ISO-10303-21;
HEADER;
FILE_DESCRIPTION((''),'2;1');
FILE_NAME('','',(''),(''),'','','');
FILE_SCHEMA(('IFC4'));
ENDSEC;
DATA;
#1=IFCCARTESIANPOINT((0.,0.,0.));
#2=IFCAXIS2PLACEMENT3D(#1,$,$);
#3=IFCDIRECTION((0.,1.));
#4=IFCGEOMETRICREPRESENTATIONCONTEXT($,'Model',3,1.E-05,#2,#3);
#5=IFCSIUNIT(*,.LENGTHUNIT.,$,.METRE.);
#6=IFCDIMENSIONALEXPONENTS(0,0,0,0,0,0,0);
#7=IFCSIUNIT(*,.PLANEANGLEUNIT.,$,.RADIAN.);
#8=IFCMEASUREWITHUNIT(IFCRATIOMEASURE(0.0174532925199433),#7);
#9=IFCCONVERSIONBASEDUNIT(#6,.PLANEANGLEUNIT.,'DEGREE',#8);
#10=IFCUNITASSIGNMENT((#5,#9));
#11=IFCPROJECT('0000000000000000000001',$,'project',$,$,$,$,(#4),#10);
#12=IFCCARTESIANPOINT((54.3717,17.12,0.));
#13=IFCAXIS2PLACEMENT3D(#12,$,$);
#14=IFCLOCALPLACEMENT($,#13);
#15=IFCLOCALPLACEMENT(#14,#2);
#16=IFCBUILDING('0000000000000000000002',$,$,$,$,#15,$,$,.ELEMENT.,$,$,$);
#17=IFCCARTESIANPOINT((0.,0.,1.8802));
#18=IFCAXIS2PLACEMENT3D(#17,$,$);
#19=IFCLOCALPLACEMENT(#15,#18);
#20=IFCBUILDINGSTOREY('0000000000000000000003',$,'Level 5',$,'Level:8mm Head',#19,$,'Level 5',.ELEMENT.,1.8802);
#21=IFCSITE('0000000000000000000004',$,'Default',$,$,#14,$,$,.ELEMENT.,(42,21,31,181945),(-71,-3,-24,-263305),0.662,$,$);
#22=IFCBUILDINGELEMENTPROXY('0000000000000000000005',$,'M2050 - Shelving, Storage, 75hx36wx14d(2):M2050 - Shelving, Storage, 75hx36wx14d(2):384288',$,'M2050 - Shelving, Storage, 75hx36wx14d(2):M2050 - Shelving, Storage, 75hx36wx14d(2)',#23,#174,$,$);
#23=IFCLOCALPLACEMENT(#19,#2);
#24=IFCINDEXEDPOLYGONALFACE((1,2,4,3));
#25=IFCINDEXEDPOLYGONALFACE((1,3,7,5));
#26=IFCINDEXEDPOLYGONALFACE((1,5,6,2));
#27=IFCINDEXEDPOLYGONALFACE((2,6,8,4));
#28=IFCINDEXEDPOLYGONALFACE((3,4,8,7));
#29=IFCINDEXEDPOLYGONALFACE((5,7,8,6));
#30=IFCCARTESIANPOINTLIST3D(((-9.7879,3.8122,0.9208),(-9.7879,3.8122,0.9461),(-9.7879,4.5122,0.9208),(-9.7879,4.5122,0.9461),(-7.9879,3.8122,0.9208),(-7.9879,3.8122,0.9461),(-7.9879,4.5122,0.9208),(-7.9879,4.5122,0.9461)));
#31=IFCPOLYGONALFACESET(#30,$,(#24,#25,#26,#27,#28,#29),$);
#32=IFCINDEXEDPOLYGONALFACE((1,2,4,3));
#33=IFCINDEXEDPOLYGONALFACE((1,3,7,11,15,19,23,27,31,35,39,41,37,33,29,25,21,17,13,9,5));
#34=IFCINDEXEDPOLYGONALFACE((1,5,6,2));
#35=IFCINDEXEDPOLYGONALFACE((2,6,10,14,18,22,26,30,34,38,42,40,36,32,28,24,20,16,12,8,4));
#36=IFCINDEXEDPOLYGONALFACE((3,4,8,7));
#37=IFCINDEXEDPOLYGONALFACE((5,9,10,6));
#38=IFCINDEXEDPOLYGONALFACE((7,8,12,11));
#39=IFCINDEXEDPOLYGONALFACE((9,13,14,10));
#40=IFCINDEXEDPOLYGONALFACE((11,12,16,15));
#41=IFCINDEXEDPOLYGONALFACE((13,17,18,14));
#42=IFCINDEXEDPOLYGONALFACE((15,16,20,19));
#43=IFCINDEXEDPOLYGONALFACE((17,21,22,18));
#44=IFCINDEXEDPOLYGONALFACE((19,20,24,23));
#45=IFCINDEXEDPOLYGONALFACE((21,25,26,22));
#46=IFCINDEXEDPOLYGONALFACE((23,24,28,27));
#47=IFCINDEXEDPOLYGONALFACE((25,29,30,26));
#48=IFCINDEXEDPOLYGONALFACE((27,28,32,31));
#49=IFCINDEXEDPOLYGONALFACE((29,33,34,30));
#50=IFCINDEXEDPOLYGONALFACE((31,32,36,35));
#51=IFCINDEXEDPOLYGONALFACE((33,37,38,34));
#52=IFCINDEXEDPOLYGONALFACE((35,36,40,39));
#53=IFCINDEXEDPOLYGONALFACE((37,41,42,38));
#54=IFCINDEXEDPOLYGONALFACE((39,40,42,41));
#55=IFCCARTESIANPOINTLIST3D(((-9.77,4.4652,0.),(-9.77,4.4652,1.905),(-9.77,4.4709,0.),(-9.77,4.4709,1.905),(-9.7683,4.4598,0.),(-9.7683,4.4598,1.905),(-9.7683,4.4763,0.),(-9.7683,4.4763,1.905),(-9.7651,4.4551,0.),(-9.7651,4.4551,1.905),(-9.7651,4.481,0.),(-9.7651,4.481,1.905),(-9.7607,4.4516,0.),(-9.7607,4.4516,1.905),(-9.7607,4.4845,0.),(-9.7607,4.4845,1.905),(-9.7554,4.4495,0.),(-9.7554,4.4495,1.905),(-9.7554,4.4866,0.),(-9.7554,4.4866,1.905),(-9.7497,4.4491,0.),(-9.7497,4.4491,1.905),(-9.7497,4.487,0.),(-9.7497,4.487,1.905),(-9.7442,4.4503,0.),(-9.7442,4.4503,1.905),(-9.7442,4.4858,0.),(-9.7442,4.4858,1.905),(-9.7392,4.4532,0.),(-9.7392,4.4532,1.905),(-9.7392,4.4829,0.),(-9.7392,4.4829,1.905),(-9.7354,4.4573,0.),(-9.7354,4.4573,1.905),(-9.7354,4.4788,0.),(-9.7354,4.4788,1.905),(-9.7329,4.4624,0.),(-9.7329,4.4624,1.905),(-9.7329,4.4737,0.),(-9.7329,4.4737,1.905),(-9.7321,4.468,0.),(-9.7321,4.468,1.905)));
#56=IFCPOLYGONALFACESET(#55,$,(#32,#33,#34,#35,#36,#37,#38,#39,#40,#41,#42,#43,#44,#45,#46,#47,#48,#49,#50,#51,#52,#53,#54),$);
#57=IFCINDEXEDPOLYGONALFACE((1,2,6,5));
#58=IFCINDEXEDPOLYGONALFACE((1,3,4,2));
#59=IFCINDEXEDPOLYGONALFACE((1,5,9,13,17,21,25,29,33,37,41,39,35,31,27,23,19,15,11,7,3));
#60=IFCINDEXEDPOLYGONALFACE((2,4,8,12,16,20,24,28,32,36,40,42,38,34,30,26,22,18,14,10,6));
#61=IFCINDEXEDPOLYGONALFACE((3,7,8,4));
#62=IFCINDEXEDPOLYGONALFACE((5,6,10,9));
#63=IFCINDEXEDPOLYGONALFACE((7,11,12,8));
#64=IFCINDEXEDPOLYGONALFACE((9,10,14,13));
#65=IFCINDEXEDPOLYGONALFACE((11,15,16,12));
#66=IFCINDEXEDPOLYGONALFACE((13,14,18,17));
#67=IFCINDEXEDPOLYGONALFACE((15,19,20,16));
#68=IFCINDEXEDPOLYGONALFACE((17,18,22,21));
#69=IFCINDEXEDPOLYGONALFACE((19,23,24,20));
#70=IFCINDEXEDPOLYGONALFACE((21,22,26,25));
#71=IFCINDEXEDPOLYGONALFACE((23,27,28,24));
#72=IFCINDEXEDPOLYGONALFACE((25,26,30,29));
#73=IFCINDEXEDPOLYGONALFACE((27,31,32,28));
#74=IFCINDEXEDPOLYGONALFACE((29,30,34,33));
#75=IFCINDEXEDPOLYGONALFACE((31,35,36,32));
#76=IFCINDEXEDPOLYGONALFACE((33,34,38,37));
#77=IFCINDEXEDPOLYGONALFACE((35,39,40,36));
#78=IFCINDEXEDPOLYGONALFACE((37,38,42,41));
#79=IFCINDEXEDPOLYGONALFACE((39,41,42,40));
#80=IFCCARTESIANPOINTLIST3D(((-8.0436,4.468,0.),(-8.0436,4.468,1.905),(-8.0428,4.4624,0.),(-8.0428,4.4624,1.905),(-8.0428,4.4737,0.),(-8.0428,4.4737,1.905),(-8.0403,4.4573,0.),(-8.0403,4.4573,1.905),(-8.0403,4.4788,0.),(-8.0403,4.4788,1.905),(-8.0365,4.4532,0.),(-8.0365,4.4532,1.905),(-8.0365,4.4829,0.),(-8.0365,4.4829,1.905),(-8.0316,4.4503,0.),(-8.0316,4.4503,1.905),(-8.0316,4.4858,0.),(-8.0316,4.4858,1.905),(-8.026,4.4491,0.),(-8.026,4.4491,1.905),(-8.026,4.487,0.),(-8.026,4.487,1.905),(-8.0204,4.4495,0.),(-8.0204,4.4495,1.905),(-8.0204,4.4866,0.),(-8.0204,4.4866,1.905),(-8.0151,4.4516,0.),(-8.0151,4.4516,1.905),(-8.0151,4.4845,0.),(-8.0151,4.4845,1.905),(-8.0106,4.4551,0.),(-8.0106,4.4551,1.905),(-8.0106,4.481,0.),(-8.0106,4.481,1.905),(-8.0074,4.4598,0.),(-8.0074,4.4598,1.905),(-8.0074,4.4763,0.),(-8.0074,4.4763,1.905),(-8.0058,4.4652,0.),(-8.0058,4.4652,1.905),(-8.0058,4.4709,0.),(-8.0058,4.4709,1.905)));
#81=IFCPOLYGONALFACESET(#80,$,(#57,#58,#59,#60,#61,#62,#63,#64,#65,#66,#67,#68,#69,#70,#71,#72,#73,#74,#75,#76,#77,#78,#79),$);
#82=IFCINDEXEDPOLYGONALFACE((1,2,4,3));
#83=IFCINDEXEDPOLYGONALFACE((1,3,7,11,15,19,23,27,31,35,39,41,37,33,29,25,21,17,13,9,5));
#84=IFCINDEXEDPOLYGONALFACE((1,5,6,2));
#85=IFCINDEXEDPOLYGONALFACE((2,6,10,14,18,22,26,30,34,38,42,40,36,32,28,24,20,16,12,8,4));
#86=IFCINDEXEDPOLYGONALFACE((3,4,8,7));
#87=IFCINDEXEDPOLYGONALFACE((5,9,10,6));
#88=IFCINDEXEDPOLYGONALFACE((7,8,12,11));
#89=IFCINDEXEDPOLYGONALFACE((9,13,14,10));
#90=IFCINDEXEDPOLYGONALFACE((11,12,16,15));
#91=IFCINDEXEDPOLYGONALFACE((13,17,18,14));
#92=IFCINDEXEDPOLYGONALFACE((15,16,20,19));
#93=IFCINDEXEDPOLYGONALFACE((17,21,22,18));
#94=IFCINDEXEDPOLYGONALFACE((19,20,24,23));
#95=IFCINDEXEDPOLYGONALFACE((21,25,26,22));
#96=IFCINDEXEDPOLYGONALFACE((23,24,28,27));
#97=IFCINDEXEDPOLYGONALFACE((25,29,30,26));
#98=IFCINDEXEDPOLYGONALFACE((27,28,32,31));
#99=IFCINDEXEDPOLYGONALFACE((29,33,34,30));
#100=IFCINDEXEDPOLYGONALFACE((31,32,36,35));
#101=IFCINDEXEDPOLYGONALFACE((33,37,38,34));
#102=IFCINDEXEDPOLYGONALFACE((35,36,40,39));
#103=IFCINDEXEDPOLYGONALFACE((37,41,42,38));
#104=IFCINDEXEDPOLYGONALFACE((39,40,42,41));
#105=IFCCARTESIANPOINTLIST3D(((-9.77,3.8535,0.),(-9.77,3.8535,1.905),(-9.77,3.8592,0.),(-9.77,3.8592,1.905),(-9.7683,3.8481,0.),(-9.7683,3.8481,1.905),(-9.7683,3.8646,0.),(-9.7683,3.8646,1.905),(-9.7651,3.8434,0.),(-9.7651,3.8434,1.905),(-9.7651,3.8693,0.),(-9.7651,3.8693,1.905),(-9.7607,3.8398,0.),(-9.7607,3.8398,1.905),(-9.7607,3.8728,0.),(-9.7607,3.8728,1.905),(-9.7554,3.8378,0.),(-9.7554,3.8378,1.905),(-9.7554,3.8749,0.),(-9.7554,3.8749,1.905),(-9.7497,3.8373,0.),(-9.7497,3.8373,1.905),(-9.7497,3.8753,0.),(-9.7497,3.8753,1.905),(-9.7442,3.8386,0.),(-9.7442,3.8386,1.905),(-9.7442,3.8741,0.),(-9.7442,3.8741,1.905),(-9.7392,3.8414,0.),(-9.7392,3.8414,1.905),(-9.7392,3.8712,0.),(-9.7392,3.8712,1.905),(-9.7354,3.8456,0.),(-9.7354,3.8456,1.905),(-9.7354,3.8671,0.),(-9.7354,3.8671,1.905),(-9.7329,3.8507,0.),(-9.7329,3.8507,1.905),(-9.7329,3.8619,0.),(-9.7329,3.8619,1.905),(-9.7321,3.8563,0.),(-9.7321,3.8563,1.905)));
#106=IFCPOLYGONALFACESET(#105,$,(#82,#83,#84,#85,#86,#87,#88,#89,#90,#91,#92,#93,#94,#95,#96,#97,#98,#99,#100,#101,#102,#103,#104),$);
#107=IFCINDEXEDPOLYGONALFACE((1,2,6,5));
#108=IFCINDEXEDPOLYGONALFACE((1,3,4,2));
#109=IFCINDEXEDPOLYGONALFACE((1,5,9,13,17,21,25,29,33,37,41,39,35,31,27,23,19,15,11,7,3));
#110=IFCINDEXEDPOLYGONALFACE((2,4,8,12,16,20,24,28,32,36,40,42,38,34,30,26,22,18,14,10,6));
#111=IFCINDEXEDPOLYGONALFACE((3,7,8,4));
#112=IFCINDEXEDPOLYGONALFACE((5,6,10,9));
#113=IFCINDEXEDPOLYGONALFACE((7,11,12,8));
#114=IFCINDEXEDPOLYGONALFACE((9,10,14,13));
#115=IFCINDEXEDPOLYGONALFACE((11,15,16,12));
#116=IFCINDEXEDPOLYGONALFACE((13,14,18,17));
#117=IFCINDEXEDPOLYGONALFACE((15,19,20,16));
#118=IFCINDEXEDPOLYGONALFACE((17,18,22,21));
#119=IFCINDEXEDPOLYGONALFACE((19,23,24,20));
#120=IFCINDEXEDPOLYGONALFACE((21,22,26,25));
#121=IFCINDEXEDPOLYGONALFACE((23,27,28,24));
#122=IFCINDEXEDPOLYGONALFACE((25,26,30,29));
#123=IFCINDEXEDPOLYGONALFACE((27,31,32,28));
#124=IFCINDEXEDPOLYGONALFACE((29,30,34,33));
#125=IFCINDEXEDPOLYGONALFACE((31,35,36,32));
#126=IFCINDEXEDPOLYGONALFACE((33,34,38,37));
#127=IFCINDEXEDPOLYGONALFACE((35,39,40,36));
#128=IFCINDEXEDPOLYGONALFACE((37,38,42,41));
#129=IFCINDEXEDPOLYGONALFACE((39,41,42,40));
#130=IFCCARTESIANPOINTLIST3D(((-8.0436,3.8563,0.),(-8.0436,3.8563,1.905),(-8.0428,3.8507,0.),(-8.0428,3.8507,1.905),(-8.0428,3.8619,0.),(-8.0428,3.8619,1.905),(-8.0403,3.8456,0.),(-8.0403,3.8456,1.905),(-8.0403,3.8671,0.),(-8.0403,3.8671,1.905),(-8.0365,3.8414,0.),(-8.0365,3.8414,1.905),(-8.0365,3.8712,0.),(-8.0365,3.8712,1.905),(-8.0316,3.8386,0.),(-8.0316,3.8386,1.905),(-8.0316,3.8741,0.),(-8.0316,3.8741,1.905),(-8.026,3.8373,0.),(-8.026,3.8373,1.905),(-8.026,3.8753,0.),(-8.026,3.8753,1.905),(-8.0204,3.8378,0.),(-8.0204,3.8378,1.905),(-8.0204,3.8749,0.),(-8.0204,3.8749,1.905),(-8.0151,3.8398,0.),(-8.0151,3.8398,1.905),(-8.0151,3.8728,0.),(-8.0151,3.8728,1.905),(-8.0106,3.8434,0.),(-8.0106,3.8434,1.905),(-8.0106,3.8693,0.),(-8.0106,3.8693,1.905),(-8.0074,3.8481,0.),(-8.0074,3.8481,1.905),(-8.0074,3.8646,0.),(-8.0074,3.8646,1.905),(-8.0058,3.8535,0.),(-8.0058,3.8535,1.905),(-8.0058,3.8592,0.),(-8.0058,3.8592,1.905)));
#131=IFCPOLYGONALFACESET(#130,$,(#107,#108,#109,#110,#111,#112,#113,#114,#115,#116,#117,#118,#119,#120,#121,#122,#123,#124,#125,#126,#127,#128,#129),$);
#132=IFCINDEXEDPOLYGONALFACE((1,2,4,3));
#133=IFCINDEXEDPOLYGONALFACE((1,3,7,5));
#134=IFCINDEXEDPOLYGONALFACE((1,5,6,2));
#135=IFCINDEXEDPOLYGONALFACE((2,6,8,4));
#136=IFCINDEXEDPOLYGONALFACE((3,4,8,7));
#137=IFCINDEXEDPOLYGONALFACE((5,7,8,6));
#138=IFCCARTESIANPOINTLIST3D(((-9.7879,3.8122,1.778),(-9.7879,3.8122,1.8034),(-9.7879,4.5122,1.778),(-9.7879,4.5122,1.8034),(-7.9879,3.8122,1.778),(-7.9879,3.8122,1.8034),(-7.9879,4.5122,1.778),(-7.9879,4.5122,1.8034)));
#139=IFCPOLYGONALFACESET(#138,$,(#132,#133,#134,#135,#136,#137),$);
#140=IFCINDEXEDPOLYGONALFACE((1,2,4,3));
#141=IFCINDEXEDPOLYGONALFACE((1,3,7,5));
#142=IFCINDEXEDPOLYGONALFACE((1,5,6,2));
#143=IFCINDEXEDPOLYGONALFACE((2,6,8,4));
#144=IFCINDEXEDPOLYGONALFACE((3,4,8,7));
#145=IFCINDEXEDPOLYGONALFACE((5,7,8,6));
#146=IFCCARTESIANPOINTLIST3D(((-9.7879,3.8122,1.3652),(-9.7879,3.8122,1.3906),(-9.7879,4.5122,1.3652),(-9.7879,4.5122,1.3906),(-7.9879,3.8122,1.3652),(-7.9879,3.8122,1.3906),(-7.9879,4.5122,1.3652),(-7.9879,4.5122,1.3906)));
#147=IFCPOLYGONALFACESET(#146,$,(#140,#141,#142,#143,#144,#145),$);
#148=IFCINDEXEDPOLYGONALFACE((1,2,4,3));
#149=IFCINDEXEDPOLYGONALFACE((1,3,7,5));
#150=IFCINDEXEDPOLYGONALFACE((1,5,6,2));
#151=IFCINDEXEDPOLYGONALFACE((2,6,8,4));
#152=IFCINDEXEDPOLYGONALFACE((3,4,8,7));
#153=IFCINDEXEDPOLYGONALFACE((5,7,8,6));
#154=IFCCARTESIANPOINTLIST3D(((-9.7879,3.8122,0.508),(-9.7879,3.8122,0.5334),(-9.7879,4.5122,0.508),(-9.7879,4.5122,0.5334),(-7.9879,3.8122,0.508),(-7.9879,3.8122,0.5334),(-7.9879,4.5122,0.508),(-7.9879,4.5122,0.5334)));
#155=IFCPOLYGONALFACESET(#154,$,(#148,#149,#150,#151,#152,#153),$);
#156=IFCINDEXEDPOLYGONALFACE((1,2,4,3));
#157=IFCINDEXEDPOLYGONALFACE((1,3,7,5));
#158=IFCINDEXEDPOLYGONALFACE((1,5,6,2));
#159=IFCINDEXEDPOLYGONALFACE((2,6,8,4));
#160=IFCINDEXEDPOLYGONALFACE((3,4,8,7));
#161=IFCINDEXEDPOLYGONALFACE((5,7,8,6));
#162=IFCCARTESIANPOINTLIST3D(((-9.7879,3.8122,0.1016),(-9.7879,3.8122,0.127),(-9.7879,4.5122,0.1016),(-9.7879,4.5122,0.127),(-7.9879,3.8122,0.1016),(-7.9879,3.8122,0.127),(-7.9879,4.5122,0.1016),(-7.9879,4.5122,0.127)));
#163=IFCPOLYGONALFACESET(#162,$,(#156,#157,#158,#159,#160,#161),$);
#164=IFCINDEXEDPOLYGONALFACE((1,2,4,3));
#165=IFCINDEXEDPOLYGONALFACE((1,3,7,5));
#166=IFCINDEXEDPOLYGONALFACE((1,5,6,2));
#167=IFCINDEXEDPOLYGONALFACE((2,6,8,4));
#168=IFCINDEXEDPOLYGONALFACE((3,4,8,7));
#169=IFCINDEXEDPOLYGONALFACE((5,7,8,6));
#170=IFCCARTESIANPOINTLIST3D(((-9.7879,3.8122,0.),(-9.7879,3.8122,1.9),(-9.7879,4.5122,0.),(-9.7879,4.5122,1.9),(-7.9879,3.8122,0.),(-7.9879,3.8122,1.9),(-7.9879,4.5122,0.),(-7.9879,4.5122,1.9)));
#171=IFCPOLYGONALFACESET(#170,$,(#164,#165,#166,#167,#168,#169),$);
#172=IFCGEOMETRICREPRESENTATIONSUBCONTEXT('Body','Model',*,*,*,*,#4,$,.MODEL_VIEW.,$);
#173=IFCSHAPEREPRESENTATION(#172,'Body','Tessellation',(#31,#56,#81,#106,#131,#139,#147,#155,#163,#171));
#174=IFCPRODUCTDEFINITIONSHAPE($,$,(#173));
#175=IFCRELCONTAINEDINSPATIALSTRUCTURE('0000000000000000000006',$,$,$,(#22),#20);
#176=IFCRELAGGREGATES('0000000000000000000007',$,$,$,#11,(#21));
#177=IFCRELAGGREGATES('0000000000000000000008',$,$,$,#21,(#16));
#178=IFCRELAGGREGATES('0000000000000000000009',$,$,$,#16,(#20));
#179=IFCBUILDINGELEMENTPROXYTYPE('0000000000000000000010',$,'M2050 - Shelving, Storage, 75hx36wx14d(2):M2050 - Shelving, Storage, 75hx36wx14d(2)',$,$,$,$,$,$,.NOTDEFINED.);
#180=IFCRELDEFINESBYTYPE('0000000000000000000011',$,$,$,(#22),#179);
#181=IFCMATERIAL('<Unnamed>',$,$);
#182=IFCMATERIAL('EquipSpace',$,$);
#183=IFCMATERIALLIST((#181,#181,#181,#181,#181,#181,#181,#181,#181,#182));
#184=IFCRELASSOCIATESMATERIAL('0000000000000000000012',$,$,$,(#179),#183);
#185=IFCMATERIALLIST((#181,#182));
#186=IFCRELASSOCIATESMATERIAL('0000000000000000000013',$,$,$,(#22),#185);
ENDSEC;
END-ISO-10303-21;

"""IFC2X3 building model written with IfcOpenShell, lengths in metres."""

from ifc_helpers import new_model, entity, si_unit, converted_unit, direction, frame, frame_2d, origin, origin_2d_with_axis, place, context, subcontext, project, spatial, rectangle, circle, extrude, source, transform, mapped, material, material_list, type_object, type_shapes, element, save


model = new_model("IFC2X3")

# Units and contexts
model_context = context("Model", 3, precision=1e-05, world=origin(), true_north=direction((0.0, 1.0)))
body_context = subcontext(model_context, "Body", "Model", "MODEL_VIEW")
ifc_project = project(units=[si_unit("LENGTHUNIT", "METRE"), converted_unit("PLANEANGLEUNIT", "DEGREE", entity("IfcRatioMeasure", 0.0174532925199433), si_unit("PLANEANGLEUNIT", "RADIAN"), dimensions=[0, 0, 0, 0, 0, 0, 0])], contexts=[model_context])

# Site, building, storey
site_placement = place(None, frame((54.3717, 17.12, 0.0)))
site = spatial("IfcSite", under=ifc_project, at=site_placement, Name="Default", CompositionType="ELEMENT", RefLatitude=(42, 21, 31, 181945), RefLongitude=(-71, -3, -24, -263305), RefElevation=0.662)
building_placement = place(site_placement, origin())
building = spatial("IfcBuilding", under=site, at=building_placement, CompositionType="ELEMENT")
storey_placement = place(building_placement, frame((0.0, 0.0, 1.8802)))
storey = spatial("IfcBuildingStorey", under=building, at=storey_placement, Name="Level 5", ObjectType="Level:8mm Head", LongName="Level 5", CompositionType="ELEMENT", Elevation=1.8802)

# Building element proxy
ifc_material_1 = material(Name="<Unnamed>")
ifc_material_2 = material(Name="EquipSpace")
ifc_material_list_1 = material_list([ifc_material_1, ifc_material_1, ifc_material_1, ifc_material_1, ifc_material_1, ifc_material_1, ifc_material_1, ifc_material_1, ifc_material_1, ifc_material_2])
building_element_proxy_type = type_object("IfcBuildingElementProxyType", Name="M2050 - Shelving, Storage, 75hx36wx14d(2):M2050 - Shelving, Storage, 75hx36wx14d(2)", PredefinedType="NOTDEFINED", material=ifc_material_list_1)
shared_shape = source(origin(), body_context, "Body", "SweptSolid", [
    extrude(rectangle(XDim=1.8, YDim=0.7, at=origin_2d_with_axis()), frame((0.0, 0.0, 0.9207), z_axis=(0.0, 0.0, 1.0), x_axis=(-1.0, 0.0, 0.0)), (0.0, 0.0, 1.0), 0.0254),
    extrude(circle(Radius=0.0191, at=origin_2d_with_axis()), frame((0.8633, -0.3059, 0.0), z_axis=(0.0, 0.0, 1.0), x_axis=(-1.0, 0.0, 0.0)), (0.0, 0.0, 1.0), 1.905),
    extrude(circle(Radius=0.0191, at=origin_2d_with_axis()), frame((-0.8633, -0.3059, 0.0)), (0.0, 0.0, 1.0), 1.905),
    extrude(circle(Radius=0.0191, at=origin_2d_with_axis()), frame((0.8633, 0.3059, 0.0), z_axis=(0.0, 0.0, 1.0), x_axis=(-1.0, 0.0, 0.0)), (0.0, 0.0, 1.0), 1.905),
    extrude(circle(Radius=0.0191, at=origin_2d_with_axis()), frame((-0.8633, 0.3059, 0.0)), (0.0, 0.0, 1.0), 1.905),
    extrude(rectangle(XDim=1.8, YDim=0.7, at=origin_2d_with_axis()), frame((0.0, 0.0, 1.778), z_axis=(0.0, 0.0, 1.0), x_axis=(-1.0, 0.0, 0.0)), (0.0, 0.0, 1.0), 0.0254),
    extrude(rectangle(XDim=1.8, YDim=0.7, at=origin_2d_with_axis()), frame((0.0, 0.0, 1.3653), z_axis=(0.0, 0.0, 1.0), x_axis=(-1.0, 0.0, 0.0)), (0.0, 0.0, 1.0), 0.0254),
    extrude(rectangle(XDim=1.8, YDim=0.7, at=origin_2d_with_axis()), frame((0.0, 0.0, 0.508), z_axis=(0.0, 0.0, 1.0), x_axis=(-1.0, 0.0, 0.0)), (0.0, 0.0, 1.0), 0.0254),
    extrude(rectangle(XDim=1.8, YDim=0.7, at=origin_2d_with_axis()), frame((0.0, 0.0, 0.1016), z_axis=(0.0, 0.0, 1.0), x_axis=(-1.0, 0.0, 0.0)), (0.0, 0.0, 1.0), 0.0254),
    extrude(rectangle(XDim=0.7, YDim=1.8, at=frame_2d((0.0, 0.18), x_axis=(1.0, 0.0))), frame((-0.18, 0.0, 0.0), z_axis=(0.0, 0.0, 1.0), x_axis=(0.0, -1.0, 0.0)), (0.0, 0.0, 1.0), 1.9),
])
type_shapes(building_element_proxy_type, [shared_shape])
ifc_material_list_2 = material_list([ifc_material_1, ifc_material_2])
proxy_1_placement = place(storey_placement, frame((-8.8879, 4.1622, 0.0), z_axis=(0.0, 0.0, 1.0), x_axis=(-1.0, 0.0, 0.0)))
element("IfcBuildingElementProxy", 1, at=proxy_1_placement, inside=storey, type_object=building_element_proxy_type, material=ifc_material_list_2, Name="M2050 - Shelving, Storage, 75hx36wx14d(2):M2050 - Shelving, Storage, 75hx36wx14d(2):384288", ObjectType="M2050 - Shelving, Storage, 75hx36wx14d(2):M2050 - Shelving, Storage, 75hx36wx14d(2)", context=body_context, shape_type="MappedRepresentation", body=[
    mapped(shared_shape, transform((0.0, 0.0, 0.0), scale=1.0)),
])

save(model, "model.ifc")
